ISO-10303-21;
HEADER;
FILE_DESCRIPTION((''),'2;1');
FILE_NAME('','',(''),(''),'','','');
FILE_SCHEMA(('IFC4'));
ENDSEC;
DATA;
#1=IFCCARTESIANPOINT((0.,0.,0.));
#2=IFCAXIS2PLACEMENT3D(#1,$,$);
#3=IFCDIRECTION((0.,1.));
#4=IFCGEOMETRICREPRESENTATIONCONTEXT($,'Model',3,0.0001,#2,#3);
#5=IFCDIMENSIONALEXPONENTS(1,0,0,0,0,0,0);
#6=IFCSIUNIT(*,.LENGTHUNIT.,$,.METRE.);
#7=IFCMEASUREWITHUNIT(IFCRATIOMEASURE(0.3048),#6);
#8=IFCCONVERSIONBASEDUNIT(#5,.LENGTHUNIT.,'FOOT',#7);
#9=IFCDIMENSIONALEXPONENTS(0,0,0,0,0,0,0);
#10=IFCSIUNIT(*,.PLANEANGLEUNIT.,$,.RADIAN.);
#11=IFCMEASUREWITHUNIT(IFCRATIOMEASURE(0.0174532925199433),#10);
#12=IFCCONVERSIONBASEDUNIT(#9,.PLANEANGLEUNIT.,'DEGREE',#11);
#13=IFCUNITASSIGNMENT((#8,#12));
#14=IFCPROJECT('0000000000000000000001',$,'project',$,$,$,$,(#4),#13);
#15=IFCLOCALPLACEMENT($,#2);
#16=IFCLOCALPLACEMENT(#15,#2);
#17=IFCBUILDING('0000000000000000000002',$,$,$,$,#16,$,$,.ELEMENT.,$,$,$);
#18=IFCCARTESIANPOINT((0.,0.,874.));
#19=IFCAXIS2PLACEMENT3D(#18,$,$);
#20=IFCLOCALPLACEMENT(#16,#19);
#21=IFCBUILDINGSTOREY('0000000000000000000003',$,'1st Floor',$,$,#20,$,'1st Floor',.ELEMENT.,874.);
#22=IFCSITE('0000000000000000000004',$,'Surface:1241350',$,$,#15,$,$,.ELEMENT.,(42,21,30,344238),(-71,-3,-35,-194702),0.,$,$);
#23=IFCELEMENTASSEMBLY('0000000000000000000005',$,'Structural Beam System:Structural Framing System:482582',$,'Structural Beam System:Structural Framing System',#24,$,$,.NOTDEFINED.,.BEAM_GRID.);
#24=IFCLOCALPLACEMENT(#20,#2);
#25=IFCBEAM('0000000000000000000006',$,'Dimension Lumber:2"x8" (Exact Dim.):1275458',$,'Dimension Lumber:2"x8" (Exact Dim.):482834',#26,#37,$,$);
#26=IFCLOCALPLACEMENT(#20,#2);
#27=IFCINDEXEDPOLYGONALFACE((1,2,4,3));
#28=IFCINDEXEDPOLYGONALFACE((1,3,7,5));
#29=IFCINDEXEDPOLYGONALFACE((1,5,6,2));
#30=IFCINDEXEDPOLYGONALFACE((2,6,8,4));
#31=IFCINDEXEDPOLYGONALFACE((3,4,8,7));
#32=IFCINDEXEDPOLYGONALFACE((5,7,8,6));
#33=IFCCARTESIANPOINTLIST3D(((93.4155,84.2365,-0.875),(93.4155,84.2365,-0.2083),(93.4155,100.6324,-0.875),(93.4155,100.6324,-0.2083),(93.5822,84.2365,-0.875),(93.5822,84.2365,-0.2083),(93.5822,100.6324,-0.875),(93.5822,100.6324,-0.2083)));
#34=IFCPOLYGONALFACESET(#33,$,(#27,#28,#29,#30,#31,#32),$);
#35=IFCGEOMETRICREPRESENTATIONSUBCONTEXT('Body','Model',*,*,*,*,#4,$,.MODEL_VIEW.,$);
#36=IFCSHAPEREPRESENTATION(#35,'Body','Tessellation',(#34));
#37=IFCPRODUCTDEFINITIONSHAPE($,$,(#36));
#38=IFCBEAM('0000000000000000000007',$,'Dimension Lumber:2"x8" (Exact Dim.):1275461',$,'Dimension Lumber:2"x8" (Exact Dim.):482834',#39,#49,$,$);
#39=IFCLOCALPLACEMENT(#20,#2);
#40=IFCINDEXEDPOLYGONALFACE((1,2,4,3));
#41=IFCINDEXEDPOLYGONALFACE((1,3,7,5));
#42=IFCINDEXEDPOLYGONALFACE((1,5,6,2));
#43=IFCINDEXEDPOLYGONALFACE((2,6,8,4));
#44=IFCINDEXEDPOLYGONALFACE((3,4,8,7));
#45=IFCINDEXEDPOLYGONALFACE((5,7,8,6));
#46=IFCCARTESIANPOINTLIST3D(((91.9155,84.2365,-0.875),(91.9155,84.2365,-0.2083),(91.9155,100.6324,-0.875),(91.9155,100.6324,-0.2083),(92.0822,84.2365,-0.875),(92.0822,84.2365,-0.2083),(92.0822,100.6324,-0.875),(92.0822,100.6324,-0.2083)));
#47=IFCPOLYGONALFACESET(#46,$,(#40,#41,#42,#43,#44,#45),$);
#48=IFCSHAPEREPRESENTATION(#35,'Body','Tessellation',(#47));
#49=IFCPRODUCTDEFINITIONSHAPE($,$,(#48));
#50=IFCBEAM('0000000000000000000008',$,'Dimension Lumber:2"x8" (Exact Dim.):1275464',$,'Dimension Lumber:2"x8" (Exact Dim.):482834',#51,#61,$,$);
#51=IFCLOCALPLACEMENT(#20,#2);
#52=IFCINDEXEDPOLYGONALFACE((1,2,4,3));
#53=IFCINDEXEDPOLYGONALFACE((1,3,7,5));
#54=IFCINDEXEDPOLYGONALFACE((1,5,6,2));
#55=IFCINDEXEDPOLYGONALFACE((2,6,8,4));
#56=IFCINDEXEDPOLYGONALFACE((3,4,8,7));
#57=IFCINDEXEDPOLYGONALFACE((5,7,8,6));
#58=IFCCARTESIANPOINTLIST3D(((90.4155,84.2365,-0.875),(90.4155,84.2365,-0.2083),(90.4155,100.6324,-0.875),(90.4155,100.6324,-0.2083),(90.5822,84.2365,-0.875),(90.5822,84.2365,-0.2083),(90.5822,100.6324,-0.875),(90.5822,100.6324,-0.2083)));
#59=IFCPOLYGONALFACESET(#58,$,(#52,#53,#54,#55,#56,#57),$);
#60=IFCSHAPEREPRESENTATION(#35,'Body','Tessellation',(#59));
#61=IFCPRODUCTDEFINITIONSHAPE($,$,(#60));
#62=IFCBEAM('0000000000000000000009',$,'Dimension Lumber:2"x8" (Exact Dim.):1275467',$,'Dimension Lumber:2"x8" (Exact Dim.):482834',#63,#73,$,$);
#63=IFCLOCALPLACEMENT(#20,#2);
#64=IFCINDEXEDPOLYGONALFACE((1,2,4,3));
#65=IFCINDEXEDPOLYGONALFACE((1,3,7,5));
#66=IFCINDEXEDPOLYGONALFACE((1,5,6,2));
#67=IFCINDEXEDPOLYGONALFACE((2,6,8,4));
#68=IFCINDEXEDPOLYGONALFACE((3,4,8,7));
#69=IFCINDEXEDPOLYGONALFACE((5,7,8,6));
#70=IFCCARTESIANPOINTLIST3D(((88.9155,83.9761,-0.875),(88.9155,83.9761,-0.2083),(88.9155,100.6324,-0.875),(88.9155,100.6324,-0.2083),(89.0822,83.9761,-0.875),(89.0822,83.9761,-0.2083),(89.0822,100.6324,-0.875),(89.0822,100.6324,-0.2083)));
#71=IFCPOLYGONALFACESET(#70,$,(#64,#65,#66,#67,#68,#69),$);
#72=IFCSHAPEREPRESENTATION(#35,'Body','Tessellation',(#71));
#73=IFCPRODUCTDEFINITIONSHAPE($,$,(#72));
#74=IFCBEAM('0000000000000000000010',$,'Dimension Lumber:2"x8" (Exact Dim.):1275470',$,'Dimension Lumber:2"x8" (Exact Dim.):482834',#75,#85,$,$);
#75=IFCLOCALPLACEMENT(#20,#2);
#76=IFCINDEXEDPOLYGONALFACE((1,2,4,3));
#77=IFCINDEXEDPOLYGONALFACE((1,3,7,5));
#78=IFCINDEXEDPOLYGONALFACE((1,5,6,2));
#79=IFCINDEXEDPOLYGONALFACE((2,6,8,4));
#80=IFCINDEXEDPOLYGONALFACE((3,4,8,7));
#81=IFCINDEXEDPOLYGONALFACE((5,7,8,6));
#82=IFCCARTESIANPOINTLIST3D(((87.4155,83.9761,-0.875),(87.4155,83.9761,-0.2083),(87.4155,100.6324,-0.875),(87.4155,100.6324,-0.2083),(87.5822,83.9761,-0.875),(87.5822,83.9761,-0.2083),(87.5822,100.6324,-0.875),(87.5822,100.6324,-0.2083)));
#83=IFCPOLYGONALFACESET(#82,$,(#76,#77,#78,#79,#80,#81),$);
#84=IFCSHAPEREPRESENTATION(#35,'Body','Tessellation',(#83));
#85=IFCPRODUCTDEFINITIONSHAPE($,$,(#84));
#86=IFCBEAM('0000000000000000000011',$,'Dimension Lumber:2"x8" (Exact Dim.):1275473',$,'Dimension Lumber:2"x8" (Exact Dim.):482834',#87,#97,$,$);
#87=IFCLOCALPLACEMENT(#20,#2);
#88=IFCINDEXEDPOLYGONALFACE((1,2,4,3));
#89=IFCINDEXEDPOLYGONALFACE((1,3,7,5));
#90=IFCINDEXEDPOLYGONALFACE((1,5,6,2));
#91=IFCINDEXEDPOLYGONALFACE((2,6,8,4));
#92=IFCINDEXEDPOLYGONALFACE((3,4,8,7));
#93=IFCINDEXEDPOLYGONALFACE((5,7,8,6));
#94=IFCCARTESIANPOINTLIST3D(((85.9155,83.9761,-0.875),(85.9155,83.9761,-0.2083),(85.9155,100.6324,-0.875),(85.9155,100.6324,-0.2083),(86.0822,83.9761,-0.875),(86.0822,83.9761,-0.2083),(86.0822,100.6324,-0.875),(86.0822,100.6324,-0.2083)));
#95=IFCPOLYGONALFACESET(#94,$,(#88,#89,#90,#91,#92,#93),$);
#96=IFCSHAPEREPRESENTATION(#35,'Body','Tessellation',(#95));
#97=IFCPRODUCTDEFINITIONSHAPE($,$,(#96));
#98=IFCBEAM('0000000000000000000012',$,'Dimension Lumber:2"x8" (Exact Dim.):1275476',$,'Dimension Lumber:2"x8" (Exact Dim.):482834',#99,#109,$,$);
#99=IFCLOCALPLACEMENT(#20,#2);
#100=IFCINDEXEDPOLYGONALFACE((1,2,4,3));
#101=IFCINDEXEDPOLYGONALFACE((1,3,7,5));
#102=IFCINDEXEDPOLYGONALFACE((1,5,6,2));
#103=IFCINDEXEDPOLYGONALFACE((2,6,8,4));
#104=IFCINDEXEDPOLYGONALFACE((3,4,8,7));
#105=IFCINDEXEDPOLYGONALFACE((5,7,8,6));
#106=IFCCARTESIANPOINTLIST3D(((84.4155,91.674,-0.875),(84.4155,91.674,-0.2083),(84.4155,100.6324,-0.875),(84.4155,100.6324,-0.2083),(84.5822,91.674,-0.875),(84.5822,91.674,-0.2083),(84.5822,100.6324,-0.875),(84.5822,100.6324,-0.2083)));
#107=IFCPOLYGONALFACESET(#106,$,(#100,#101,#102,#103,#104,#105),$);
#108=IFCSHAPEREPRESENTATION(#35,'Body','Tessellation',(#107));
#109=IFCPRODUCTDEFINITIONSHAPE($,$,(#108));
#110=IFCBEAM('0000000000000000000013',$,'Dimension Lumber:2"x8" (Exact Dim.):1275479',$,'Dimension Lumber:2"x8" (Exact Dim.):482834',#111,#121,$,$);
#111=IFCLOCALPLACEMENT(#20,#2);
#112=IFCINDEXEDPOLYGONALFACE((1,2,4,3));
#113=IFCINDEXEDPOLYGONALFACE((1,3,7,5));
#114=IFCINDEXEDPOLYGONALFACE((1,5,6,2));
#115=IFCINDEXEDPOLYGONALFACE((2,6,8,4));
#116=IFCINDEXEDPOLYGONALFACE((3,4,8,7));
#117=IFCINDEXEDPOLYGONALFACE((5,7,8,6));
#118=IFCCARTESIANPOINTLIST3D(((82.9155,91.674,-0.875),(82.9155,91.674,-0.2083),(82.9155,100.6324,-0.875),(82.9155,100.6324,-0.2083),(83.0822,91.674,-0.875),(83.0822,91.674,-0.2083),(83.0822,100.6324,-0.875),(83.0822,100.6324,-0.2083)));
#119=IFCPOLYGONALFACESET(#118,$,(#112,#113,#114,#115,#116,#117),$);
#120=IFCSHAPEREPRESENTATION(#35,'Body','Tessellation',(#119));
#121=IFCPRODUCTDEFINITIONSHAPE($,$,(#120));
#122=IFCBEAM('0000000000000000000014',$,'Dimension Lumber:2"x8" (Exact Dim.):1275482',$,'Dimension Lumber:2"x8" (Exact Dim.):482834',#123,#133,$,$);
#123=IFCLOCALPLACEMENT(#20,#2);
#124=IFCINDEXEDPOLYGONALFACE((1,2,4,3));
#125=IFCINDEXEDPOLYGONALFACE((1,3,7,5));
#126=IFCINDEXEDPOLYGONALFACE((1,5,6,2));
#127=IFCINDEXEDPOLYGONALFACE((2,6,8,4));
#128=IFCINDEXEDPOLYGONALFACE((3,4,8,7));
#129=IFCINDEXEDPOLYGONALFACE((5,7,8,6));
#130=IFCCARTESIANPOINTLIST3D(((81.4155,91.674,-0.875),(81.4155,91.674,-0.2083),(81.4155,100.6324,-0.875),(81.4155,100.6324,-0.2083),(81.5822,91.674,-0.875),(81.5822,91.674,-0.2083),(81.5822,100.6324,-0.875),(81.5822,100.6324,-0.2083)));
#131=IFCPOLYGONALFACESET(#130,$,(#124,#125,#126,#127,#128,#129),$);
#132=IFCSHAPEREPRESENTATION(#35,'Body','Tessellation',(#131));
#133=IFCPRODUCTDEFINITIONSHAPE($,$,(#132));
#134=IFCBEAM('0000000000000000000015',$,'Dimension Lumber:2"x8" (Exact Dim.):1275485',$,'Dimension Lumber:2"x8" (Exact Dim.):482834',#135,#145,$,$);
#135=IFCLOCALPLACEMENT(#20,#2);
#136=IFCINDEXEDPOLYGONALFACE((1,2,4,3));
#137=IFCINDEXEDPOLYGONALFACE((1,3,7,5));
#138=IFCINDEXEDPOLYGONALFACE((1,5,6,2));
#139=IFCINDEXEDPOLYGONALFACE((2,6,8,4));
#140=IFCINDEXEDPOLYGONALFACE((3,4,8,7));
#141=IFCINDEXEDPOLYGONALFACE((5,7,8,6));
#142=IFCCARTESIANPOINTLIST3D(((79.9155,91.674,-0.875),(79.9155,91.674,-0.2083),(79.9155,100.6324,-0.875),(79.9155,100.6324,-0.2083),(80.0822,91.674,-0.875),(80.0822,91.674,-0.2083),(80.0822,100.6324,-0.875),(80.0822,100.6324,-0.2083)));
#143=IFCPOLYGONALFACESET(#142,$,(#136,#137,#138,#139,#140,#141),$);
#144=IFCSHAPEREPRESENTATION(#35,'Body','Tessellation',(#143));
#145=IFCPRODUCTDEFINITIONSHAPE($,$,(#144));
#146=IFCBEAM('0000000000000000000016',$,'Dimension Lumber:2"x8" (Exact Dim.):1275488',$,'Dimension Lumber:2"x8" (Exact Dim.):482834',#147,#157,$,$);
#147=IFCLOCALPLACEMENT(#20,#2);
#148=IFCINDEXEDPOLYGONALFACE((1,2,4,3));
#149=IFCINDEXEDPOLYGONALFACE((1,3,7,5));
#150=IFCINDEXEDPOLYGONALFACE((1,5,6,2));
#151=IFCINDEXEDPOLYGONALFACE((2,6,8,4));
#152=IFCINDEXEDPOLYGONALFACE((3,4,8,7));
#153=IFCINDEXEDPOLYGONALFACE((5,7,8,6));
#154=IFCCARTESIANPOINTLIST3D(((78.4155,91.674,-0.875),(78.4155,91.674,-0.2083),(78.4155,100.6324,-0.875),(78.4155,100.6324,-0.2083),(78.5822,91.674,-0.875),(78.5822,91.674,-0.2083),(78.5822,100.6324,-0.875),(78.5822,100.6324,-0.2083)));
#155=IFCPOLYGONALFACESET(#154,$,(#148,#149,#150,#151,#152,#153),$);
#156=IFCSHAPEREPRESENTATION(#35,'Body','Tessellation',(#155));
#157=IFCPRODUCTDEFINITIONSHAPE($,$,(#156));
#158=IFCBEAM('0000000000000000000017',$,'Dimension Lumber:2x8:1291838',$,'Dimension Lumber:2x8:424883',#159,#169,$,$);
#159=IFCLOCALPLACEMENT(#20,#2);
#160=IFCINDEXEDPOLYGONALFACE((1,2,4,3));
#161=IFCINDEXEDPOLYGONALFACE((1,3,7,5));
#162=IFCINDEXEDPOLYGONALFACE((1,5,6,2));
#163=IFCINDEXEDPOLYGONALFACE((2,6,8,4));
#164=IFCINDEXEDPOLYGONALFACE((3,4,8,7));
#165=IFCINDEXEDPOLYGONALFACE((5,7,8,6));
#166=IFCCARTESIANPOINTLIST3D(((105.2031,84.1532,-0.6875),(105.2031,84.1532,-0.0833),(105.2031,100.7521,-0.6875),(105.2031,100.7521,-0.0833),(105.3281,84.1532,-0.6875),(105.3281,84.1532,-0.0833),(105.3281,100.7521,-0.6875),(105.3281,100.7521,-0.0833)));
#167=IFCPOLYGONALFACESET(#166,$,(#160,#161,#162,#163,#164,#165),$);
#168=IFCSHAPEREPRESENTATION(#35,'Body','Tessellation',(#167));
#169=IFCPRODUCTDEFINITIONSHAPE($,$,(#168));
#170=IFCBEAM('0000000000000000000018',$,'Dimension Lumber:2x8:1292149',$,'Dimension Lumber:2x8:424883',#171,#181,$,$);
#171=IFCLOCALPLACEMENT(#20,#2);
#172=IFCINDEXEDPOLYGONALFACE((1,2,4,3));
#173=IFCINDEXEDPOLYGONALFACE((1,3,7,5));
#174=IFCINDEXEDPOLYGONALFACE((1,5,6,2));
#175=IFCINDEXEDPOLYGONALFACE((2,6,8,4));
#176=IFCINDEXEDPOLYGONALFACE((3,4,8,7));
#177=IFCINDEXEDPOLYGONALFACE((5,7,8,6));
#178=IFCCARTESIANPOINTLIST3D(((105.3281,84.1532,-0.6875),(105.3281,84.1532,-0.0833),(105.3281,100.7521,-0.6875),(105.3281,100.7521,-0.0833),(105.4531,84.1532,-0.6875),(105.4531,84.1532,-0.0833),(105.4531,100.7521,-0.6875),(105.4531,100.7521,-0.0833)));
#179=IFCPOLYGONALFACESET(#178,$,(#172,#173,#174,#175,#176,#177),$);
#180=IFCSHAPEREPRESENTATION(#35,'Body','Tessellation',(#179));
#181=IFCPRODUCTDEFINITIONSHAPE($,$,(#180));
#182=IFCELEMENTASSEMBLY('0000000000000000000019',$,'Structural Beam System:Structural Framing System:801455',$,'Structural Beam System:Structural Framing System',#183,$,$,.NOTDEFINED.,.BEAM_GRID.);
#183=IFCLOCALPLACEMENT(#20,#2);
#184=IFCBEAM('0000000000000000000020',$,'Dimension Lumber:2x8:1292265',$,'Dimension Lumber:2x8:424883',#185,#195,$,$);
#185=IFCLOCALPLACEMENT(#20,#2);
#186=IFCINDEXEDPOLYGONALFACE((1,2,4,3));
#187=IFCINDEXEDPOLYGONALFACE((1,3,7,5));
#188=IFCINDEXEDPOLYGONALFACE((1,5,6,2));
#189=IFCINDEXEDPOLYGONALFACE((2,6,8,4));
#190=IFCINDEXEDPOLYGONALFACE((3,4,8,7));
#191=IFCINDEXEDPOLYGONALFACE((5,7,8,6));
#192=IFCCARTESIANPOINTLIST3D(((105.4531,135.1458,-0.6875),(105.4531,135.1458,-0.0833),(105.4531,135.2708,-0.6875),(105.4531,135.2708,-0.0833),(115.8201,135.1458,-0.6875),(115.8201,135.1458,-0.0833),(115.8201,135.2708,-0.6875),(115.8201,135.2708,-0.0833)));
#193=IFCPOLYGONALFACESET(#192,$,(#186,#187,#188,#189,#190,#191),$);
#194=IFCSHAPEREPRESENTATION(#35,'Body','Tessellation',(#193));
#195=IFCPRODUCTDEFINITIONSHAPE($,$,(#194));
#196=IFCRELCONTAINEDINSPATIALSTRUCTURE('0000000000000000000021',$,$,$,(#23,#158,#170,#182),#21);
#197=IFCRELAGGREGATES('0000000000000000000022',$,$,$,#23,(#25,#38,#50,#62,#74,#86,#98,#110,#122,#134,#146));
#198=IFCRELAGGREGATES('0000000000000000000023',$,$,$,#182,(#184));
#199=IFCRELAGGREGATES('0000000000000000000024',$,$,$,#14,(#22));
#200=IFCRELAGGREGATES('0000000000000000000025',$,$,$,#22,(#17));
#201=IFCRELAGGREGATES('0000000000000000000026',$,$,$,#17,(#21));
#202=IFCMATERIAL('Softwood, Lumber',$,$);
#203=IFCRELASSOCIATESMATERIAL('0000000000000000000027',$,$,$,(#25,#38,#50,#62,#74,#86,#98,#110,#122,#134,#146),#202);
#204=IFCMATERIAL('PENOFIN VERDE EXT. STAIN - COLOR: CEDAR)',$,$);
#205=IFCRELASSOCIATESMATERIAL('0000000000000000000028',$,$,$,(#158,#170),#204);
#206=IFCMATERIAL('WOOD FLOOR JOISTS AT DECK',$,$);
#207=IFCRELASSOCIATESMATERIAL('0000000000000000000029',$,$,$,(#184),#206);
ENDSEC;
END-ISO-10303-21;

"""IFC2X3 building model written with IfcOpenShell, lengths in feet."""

from ifc_helpers import new_model, entity, si_unit, converted_unit, direction, frame, frame_2d, origin, place, context, subcontext, project, spatial, rectangle, extrude, material, element, aggregate, save


model = new_model("IFC2X3")

# Units and contexts
model_context = context("Model", 3, precision=0.0001, world=origin(), true_north=direction((0.0, 1.0)))
body_context = subcontext(model_context, "Body", "Model", "MODEL_VIEW")
ifc_project = project(units=[converted_unit("LENGTHUNIT", "FOOT", entity("IfcRatioMeasure", 0.3048), si_unit("LENGTHUNIT", "METRE"), dimensions=[1, 0, 0, 0, 0, 0, 0]), converted_unit("PLANEANGLEUNIT", "DEGREE", entity("IfcRatioMeasure", 0.0174532925199433), si_unit("PLANEANGLEUNIT", "RADIAN"), dimensions=[0, 0, 0, 0, 0, 0, 0])], contexts=[model_context])

# Site, building, storey
site_placement = place(None, origin())
site = spatial("IfcSite", under=ifc_project, at=site_placement, Name="Surface:1241350", CompositionType="ELEMENT", RefLatitude=(42, 21, 30, 344238), RefLongitude=(-71, -3, -35, -194702), RefElevation=0.0)
building_placement = place(site_placement, origin())
building = spatial("IfcBuilding", under=site, at=building_placement, CompositionType="ELEMENT")
storey_placement = place(building_placement, frame((0.0, 0.0, 874.0)))
storey = spatial("IfcBuildingStorey", under=building, at=storey_placement, Name="1st Floor", LongName="1st Floor", CompositionType="ELEMENT", Elevation=874.0)

# Element assembly, beams
assembly_1_placement = place(storey_placement, origin())
assembly_1 = element("IfcElementAssembly", 1, at=assembly_1_placement, inside=storey, Name="Structural Beam System:Structural Framing System:482582", ObjectType="Structural Beam System:Structural Framing System", AssemblyPlace="NOTDEFINED", PredefinedType="BEAM_GRID")
ifc_material_1 = material(Name="Softwood, Lumber")
beam_1_placement = place(assembly_1_placement, frame((93.4988, 100.9657, 0.0), z_axis=(0.0, 0.0, 1.0), x_axis=(0.0, -1.0, 0.0)))
beam_1 = element("IfcBeam", 2, at=beam_1_placement, material=ifc_material_1, Name="Dimension Lumber:2\"x8\" (Exact Dim.):1275458", ObjectType="Dimension Lumber:2\"x8\" (Exact Dim.):482834", context=body_context, shape_type="SweptSolid", body=[
    extrude(rectangle(XDim=0.6667, YDim=0.1667, at=frame_2d((0.0, 0.0), x_axis=(1.0, 0.0))), frame((0.3333, 0.0, -0.5417), z_axis=(1.0, 0.0, 0.0), x_axis=(0.0, 0.0, -1.0)), (0.0, 0.0, 1.0), 16.3958),
])
beam_2_placement = place(assembly_1_placement, frame((91.9988, 100.9657, 0.0), z_axis=(0.0, 0.0, 1.0), x_axis=(0.0, -1.0, 0.0)))
beam_2 = element("IfcBeam", 3, at=beam_2_placement, material=ifc_material_1, Name="Dimension Lumber:2\"x8\" (Exact Dim.):1275461", ObjectType="Dimension Lumber:2\"x8\" (Exact Dim.):482834", context=body_context, shape_type="SweptSolid", body=[
    extrude(rectangle(XDim=0.6667, YDim=0.1667, at=frame_2d((0.0, 0.0), x_axis=(1.0, 0.0))), frame((0.3333, 0.0, -0.5417), z_axis=(1.0, 0.0, 0.0), x_axis=(0.0, 0.0, -1.0)), (0.0, 0.0, 1.0), 16.3958),
])
beam_3_placement = place(assembly_1_placement, frame((90.4988, 100.9657, 0.0), z_axis=(0.0, 0.0, 1.0), x_axis=(0.0, -1.0, 0.0)))
beam_3 = element("IfcBeam", 4, at=beam_3_placement, material=ifc_material_1, Name="Dimension Lumber:2\"x8\" (Exact Dim.):1275464", ObjectType="Dimension Lumber:2\"x8\" (Exact Dim.):482834", context=body_context, shape_type="SweptSolid", body=[
    extrude(rectangle(XDim=0.6667, YDim=0.1667, at=frame_2d((0.0, 0.0), x_axis=(1.0, 0.0))), frame((0.3333, 0.0, -0.5417), z_axis=(1.0, 0.0, 0.0), x_axis=(0.0, 0.0, -1.0)), (0.0, 0.0, 1.0), 16.3958),
])
beam_4_placement = place(assembly_1_placement, frame((88.9988, 100.9657, 0.0), z_axis=(0.0, 0.0, 1.0), x_axis=(0.0, -1.0, 0.0)))
beam_4 = element("IfcBeam", 5, at=beam_4_placement, material=ifc_material_1, Name="Dimension Lumber:2\"x8\" (Exact Dim.):1275467", ObjectType="Dimension Lumber:2\"x8\" (Exact Dim.):482834", context=body_context, shape_type="SweptSolid", body=[
    extrude(rectangle(XDim=0.6667, YDim=0.1667, at=frame_2d((0.0, 0.0), x_axis=(1.0, 0.0))), frame((0.3333, 0.0, -0.5417), z_axis=(1.0, 0.0, 0.0), x_axis=(0.0, 0.0, -1.0)), (0.0, 0.0, 1.0), 16.6563),
])
beam_5_placement = place(assembly_1_placement, frame((87.4988, 100.9657, 0.0), z_axis=(0.0, 0.0, 1.0), x_axis=(0.0, -1.0, 0.0)))
beam_5 = element("IfcBeam", 6, at=beam_5_placement, material=ifc_material_1, Name="Dimension Lumber:2\"x8\" (Exact Dim.):1275470", ObjectType="Dimension Lumber:2\"x8\" (Exact Dim.):482834", context=body_context, shape_type="SweptSolid", body=[
    extrude(rectangle(XDim=0.6667, YDim=0.1667, at=frame_2d((0.0, 0.0), x_axis=(1.0, 0.0))), frame((0.3333, 0.0, -0.5417), z_axis=(1.0, 0.0, 0.0), x_axis=(0.0, 0.0, -1.0)), (0.0, 0.0, 1.0), 16.6563),
])
beam_6_placement = place(assembly_1_placement, frame((85.9988, 100.9657, 0.0), z_axis=(0.0, 0.0, 1.0), x_axis=(0.0, -1.0, 0.0)))
beam_6 = element("IfcBeam", 7, at=beam_6_placement, material=ifc_material_1, Name="Dimension Lumber:2\"x8\" (Exact Dim.):1275473", ObjectType="Dimension Lumber:2\"x8\" (Exact Dim.):482834", context=body_context, shape_type="SweptSolid", body=[
    extrude(rectangle(XDim=0.6667, YDim=0.1667, at=frame_2d((0.0, 0.0), x_axis=(1.0, 0.0))), frame((0.3333, 0.0, -0.5417), z_axis=(1.0, 0.0, 0.0), x_axis=(0.0, 0.0, -1.0)), (0.0, 0.0, 1.0), 16.6563),
])
beam_7_placement = place(assembly_1_placement, frame((84.4988, 100.9657, 0.0), z_axis=(0.0, 0.0, 1.0), x_axis=(0.0, -1.0, 0.0)))
beam_7 = element("IfcBeam", 8, at=beam_7_placement, material=ifc_material_1, Name="Dimension Lumber:2\"x8\" (Exact Dim.):1275476", ObjectType="Dimension Lumber:2\"x8\" (Exact Dim.):482834", context=body_context, shape_type="SweptSolid", body=[
    extrude(rectangle(XDim=0.6667, YDim=0.1667, at=frame_2d((0.0, 0.0), x_axis=(1.0, 0.0))), frame((0.3333, 0.0, -0.5417), z_axis=(1.0, 0.0, 0.0), x_axis=(0.0, 0.0, -1.0)), (0.0, 0.0, 1.0), 8.9583),
])
beam_8_placement = place(assembly_1_placement, frame((82.9988, 100.9657, 0.0), z_axis=(0.0, 0.0, 1.0), x_axis=(0.0, -1.0, 0.0)))
beam_8 = element("IfcBeam", 9, at=beam_8_placement, material=ifc_material_1, Name="Dimension Lumber:2\"x8\" (Exact Dim.):1275479", ObjectType="Dimension Lumber:2\"x8\" (Exact Dim.):482834", context=body_context, shape_type="SweptSolid", body=[
    extrude(rectangle(XDim=0.6667, YDim=0.1667, at=frame_2d((0.0, 0.0), x_axis=(1.0, 0.0))), frame((0.3333, 0.0, -0.5417), z_axis=(1.0, 0.0, 0.0), x_axis=(0.0, 0.0, -1.0)), (0.0, 0.0, 1.0), 8.9583),
])
beam_9_placement = place(assembly_1_placement, frame((81.4988, 100.9657, 0.0), z_axis=(0.0, 0.0, 1.0), x_axis=(0.0, -1.0, 0.0)))
beam_9 = element("IfcBeam", 10, at=beam_9_placement, material=ifc_material_1, Name="Dimension Lumber:2\"x8\" (Exact Dim.):1275482", ObjectType="Dimension Lumber:2\"x8\" (Exact Dim.):482834", context=body_context, shape_type="SweptSolid", body=[
    extrude(rectangle(XDim=0.6667, YDim=0.1667, at=frame_2d((0.0, 0.0), x_axis=(1.0, 0.0))), frame((0.3333, 0.0, -0.5417), z_axis=(1.0, 0.0, 0.0), x_axis=(0.0, 0.0, -1.0)), (0.0, 0.0, 1.0), 8.9583),
])
beam_10_placement = place(assembly_1_placement, frame((79.9988, 100.9657, 0.0), z_axis=(0.0, 0.0, 1.0), x_axis=(0.0, -1.0, 0.0)))
beam_10 = element("IfcBeam", 11, at=beam_10_placement, material=ifc_material_1, Name="Dimension Lumber:2\"x8\" (Exact Dim.):1275485", ObjectType="Dimension Lumber:2\"x8\" (Exact Dim.):482834", context=body_context, shape_type="SweptSolid", body=[
    extrude(rectangle(XDim=0.6667, YDim=0.1667, at=frame_2d((0.0, 0.0), x_axis=(1.0, 0.0))), frame((0.3333, 0.0, -0.5417), z_axis=(1.0, 0.0, 0.0), x_axis=(0.0, 0.0, -1.0)), (0.0, 0.0, 1.0), 8.9583),
])
beam_11_placement = place(assembly_1_placement, frame((78.4988, 100.9657, 0.0), z_axis=(0.0, 0.0, 1.0), x_axis=(0.0, -1.0, 0.0)))
beam_11 = element("IfcBeam", 12, at=beam_11_placement, material=ifc_material_1, Name="Dimension Lumber:2\"x8\" (Exact Dim.):1275488", ObjectType="Dimension Lumber:2\"x8\" (Exact Dim.):482834", context=body_context, shape_type="SweptSolid", body=[
    extrude(rectangle(XDim=0.6667, YDim=0.1667, at=frame_2d((0.0, 0.0), x_axis=(1.0, 0.0))), frame((0.3333, 0.0, -0.5417), z_axis=(1.0, 0.0, 0.0), x_axis=(0.0, 0.0, -1.0)), (0.0, 0.0, 1.0), 8.9583),
])
aggregate(assembly_1, [beam_1, beam_2, beam_3, beam_4, beam_5, beam_6, beam_7, beam_8, beam_9, beam_10, beam_11])

# Beams
ifc_material_2 = material(Name="PENOFIN VERDE EXT. STAIN - COLOR: CEDAR)")
for number, where, z_axis, x_axis, name in (
    (13, (105.2656, 84.1532, 0.0), (0.0, 0.0, 1.0), (0.0, 1.0, 0.0), "Dimension Lumber:2x8:1291838"),
    (14, (105.3906, 84.1532, 0.0), (0.0, 0.0, 1.0), (0.0, 1.0, 0.0), "Dimension Lumber:2x8:1292149"),
):
    element("IfcBeam", number, at=place(storey_placement, frame(where, z_axis=z_axis, x_axis=x_axis)), inside=storey, material=ifc_material_2, Name=name, ObjectType="Dimension Lumber:2x8:424883", context=body_context, shape_type="SweptSolid", body=[
        extrude(rectangle(XDim=0.6042, YDim=0.125, at=frame_2d((0.0, 0.0), x_axis=(1.0, 0.0))), frame((0.0, 0.0, -0.3854), z_axis=(1.0, 0.0, 0.0), x_axis=(0.0, 0.0, -1.0)), (0.0, 0.0, 1.0), 16.599),
    ])

# Element assembly, beam
assembly_2_placement = place(storey_placement, origin())
assembly_2 = element("IfcElementAssembly", 15, at=assembly_2_placement, inside=storey, Name="Structural Beam System:Structural Framing System:801455", ObjectType="Structural Beam System:Structural Framing System", AssemblyPlace="NOTDEFINED", PredefinedType="BEAM_GRID")
ifc_material_3 = material(Name="WOOD FLOOR JOISTS AT DECK")
beam_12_placement = place(assembly_2_placement, frame((105.3906, 135.2083, 0.0)))
beam_12 = element("IfcBeam", 16, at=beam_12_placement, material=ifc_material_3, Name="Dimension Lumber:2x8:1292265", ObjectType="Dimension Lumber:2x8:424883", context=body_context, shape_type="SweptSolid", body=[
    extrude(rectangle(XDim=0.6042, YDim=0.125, at=frame_2d((0.0, 0.0), x_axis=(1.0, 0.0))), frame((0.0625, 0.0, -0.3854), z_axis=(1.0, 0.0, 0.0), x_axis=(0.0, 0.0, -1.0)), (0.0, 0.0, 1.0), 10.367),
])
aggregate(assembly_2, [beam_12])

save(model, "model.ifc")
